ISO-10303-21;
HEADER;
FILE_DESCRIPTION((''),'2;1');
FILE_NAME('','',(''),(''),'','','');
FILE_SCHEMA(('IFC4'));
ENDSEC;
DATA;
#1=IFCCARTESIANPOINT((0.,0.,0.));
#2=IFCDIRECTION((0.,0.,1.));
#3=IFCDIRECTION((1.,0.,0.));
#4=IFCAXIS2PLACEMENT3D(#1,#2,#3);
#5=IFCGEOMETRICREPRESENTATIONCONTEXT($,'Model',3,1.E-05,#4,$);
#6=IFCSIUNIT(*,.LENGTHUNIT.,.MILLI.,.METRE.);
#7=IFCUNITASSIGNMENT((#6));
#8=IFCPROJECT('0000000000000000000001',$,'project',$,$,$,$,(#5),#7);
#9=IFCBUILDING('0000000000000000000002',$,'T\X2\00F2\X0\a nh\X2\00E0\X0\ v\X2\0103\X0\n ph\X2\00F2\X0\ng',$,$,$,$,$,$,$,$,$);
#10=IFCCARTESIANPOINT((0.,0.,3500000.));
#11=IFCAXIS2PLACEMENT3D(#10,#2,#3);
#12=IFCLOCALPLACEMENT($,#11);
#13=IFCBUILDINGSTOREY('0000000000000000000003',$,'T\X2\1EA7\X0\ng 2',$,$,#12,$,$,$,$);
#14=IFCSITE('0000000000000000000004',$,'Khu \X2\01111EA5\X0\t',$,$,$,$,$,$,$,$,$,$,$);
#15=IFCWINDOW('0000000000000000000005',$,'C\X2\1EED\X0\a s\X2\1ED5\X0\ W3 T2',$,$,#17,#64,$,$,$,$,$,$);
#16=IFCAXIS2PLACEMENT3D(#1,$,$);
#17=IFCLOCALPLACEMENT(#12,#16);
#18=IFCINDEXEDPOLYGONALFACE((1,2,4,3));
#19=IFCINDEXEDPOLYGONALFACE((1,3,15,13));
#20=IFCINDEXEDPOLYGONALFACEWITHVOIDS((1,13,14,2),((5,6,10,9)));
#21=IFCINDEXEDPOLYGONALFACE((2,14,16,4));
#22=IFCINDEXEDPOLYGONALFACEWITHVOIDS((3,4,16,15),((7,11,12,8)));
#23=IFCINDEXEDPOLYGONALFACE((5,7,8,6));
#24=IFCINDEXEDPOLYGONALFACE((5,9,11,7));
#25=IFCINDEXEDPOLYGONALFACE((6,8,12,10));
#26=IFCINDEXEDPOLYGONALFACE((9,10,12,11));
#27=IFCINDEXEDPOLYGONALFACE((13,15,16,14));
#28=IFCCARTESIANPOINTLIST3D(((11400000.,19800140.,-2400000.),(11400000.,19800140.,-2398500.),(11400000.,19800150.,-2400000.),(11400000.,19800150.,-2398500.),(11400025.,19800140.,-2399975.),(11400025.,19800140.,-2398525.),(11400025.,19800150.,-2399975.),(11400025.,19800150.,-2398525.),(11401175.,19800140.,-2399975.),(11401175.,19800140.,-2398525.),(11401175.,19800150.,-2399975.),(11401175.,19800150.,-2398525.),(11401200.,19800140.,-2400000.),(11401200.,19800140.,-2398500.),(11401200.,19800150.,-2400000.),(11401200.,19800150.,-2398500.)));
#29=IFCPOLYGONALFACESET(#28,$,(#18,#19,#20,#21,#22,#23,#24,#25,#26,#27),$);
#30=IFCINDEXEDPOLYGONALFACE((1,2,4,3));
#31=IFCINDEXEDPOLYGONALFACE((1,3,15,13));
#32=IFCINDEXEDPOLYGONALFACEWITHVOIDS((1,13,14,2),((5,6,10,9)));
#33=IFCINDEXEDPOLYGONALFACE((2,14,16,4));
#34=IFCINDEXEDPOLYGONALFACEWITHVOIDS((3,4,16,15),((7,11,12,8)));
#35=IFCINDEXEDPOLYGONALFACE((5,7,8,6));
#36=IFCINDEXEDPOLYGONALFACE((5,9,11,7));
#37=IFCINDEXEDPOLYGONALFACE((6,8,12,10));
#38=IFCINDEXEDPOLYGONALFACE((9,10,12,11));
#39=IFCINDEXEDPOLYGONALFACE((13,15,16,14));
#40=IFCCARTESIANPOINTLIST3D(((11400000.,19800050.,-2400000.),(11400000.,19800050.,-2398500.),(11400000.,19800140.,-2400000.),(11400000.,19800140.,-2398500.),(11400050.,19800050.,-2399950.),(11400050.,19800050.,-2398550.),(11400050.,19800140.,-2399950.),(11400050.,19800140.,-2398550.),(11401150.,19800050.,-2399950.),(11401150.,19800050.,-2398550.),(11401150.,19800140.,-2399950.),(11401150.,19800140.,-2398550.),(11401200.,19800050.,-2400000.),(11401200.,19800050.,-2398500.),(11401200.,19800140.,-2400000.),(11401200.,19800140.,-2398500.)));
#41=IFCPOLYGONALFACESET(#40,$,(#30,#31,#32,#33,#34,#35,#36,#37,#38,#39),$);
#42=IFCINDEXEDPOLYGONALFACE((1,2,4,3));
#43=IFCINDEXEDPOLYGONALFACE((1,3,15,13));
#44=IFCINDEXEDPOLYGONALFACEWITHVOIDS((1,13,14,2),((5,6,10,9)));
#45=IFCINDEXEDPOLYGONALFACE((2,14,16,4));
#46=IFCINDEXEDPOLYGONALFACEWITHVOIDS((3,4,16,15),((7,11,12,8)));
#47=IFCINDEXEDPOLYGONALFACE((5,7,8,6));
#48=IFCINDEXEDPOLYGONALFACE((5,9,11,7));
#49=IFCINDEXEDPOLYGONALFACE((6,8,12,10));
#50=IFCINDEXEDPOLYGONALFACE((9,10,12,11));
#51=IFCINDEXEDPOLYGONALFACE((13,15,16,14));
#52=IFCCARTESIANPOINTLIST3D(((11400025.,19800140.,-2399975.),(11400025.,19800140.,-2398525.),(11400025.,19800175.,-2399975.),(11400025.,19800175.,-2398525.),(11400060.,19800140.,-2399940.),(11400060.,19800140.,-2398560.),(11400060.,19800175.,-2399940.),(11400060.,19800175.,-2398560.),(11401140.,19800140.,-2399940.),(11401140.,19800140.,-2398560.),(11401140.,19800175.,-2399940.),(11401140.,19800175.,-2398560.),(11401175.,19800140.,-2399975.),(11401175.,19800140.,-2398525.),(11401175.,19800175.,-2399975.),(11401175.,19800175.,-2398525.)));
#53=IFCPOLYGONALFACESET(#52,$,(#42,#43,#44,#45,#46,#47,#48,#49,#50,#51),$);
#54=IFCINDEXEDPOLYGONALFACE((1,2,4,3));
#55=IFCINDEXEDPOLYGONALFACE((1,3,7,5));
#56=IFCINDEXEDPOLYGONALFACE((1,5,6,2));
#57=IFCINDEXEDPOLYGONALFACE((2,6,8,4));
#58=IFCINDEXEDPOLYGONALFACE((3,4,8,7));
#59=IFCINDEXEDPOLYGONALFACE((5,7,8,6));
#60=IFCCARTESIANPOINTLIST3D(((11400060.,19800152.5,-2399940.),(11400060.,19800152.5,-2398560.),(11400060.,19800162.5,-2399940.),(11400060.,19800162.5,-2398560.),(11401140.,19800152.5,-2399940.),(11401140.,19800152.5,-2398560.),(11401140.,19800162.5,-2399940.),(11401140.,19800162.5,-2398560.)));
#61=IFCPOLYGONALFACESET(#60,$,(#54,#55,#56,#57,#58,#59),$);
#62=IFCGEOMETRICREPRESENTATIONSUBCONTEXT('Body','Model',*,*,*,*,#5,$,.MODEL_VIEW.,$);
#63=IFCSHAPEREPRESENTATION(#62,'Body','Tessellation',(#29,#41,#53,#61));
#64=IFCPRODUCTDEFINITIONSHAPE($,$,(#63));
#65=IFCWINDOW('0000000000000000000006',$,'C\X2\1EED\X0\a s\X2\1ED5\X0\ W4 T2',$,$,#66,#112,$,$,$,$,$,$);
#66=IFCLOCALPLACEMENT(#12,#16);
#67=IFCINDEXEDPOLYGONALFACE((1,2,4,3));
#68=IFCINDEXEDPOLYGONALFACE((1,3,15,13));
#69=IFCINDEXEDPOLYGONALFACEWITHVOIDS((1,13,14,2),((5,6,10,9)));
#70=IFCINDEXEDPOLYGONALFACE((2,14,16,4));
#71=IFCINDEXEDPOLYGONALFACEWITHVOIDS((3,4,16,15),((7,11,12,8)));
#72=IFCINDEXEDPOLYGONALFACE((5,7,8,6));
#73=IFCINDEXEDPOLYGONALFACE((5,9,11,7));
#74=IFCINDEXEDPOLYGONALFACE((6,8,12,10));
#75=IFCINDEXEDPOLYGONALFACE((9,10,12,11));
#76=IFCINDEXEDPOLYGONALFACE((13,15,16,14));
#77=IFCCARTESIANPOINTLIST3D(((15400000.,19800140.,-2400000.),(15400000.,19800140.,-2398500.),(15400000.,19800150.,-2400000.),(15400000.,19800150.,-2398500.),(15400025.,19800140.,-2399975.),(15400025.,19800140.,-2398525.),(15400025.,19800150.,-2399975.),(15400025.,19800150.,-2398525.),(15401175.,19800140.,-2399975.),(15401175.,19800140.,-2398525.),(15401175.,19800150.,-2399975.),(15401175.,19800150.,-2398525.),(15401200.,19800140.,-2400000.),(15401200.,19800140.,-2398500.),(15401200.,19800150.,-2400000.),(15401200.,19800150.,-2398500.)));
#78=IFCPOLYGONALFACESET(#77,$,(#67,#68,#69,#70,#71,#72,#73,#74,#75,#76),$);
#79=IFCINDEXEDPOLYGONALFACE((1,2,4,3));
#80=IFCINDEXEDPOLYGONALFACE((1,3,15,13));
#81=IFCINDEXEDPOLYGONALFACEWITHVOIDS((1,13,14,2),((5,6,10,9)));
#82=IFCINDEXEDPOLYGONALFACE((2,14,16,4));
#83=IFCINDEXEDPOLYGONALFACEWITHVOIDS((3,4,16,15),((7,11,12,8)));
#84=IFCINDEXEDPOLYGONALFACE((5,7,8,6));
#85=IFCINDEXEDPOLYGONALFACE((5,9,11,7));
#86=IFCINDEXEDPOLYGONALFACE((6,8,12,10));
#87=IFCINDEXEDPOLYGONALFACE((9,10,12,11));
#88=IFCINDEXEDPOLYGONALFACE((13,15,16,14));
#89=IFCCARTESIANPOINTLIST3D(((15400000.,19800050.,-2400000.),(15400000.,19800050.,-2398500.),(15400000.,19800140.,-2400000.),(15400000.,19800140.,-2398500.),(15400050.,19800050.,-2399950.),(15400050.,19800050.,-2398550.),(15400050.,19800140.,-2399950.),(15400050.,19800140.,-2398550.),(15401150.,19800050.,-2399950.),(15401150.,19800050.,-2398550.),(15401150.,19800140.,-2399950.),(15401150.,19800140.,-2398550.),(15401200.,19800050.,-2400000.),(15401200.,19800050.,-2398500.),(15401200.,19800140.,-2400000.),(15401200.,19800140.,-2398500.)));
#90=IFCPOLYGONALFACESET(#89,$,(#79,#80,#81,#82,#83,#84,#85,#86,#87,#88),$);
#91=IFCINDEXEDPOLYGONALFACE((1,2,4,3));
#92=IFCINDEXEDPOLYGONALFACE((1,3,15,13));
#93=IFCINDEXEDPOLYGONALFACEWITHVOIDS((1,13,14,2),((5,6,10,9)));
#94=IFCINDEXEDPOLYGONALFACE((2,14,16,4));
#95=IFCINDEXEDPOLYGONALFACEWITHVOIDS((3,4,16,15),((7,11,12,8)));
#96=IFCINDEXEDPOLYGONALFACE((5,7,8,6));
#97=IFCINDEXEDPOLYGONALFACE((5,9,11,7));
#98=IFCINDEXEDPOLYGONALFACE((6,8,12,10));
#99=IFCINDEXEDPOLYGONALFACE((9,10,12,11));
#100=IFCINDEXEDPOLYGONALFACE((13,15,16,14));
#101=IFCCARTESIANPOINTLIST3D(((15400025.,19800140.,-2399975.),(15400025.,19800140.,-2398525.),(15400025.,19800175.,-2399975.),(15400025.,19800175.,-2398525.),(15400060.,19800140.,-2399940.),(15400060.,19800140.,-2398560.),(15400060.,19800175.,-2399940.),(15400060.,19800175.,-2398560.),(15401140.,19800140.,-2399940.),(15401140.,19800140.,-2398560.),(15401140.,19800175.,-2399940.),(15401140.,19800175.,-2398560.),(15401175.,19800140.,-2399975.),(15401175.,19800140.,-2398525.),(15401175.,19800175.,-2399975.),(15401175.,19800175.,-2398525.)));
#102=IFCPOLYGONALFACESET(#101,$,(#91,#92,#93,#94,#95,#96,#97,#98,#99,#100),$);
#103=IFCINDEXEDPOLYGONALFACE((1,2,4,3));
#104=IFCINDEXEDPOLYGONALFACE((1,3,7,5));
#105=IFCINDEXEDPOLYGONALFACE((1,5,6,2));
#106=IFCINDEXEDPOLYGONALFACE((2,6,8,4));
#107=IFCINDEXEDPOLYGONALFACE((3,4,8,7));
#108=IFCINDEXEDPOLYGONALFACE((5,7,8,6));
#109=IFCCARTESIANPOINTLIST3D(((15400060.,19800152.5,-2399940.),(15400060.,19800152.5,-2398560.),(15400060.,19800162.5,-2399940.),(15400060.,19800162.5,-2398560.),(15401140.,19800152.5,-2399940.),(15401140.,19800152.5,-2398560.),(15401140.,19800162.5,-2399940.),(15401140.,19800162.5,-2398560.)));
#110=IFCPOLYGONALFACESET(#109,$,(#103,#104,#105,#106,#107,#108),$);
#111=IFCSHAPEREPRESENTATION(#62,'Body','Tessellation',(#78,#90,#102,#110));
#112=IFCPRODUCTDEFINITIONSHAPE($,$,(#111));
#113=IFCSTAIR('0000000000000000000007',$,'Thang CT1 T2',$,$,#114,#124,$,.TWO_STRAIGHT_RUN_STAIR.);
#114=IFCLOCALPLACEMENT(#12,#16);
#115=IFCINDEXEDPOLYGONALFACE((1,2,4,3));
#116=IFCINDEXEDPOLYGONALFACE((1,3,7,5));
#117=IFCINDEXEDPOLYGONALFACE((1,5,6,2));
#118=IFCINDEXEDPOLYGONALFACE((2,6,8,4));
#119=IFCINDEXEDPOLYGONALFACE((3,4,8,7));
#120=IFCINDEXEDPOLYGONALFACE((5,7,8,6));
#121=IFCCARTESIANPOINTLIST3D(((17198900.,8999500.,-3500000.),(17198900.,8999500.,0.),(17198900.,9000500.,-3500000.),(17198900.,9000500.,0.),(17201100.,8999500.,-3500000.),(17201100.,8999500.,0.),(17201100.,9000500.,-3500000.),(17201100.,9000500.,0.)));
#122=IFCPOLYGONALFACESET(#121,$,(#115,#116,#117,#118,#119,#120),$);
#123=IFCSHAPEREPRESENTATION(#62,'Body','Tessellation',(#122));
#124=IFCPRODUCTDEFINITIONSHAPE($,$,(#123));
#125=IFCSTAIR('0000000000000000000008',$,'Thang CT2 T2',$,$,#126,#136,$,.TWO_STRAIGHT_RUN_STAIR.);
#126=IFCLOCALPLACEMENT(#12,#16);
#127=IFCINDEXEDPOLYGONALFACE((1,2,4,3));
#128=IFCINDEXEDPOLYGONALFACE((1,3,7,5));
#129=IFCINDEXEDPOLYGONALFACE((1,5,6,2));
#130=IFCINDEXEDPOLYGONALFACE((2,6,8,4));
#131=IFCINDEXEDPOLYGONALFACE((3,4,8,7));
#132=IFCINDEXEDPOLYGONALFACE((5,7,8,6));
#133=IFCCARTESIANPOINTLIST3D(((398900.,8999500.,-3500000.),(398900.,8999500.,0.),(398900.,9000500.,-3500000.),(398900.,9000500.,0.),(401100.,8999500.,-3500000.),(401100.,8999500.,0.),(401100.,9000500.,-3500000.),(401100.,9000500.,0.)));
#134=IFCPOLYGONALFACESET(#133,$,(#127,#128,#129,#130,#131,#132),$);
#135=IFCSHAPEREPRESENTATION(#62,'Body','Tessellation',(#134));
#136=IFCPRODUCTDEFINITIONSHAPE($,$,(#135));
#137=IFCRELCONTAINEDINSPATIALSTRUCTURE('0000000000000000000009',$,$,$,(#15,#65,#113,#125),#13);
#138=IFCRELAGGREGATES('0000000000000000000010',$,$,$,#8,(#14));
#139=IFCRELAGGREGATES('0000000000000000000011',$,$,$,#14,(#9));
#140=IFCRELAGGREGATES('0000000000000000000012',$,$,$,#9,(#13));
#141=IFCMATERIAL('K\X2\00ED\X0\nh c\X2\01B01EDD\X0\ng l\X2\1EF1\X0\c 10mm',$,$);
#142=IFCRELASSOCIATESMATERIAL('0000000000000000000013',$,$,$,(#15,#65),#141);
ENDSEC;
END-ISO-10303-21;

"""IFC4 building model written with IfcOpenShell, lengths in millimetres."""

from ifc_helpers import new_model, entity, si_unit, frame, origin_with_axes, place, context, subcontext, project, spatial, line, indexed_curve, outline, extrude, material, element, save


model = new_model("IFC4")

# Units and contexts
model_context = context("Model", 3, precision=1e-05, world=origin_with_axes())
body_context = subcontext(model_context, "Body", "Model", "MODEL_VIEW")
ifc_project = project(units=[si_unit("LENGTHUNIT", "METRE", prefix="MILLI")], contexts=[model_context])

# Site, building, storey
site = spatial("IfcSite", under=ifc_project, Name="Khu đất")
building = spatial("IfcBuilding", under=site, Name="Tòa nhà văn phòng")
storey_placement = place(None, frame((0.0, 0.0, 3500000.0), z_axis=(0.0, 0.0, 1.0), x_axis=(1.0, 0.0, 0.0)))
storey = spatial("IfcBuildingStorey", under=building, at=storey_placement, Name="Tầng 2")

# Windows
ifc_material_1 = material(Name="Kính cường lực 10mm")
for number, where, z_axis, x_axis, name in (
    (1, (11400000.0, 19800000.0, -2400000.0), (0.0, 0.0, 1.0), (1.0, 0.0, 0.0), "Cửa sổ W3 T2"),
    (2, (15400000.0, 19800000.0, -2400000.0), (0.0, 0.0, 1.0), (1.0, 0.0, 0.0), "Cửa sổ W4 T2"),
):
    element("IfcWindow", number, at=place(storey_placement, frame(where, z_axis=z_axis, x_axis=x_axis)), inside=storey, material=ifc_material_1, Name=name, context=body_context, shape_type="SolidModel", body=[
        extrude(outline(indexed_curve([(0.0, 0.0), (1200.0, 0.0), (1200.0, 1500.0), (0.0, 1500.0)], segments=[line(1, 2, 3, 4, 1)]), holes=[indexed_curve([(25.0, 25.0), (1175.0, 25.0), (1175.0, 1475.0), (25.0, 1475.0)], segments=[line(1, 2, 3, 4, 1)])]), frame((0.0, 140.0, 0.0), z_axis=(0.0, -1.0, 0.0), x_axis=(1.0, 0.0, 0.0)), (0.0, 0.0, -1.0), 10.0),
        extrude(outline(indexed_curve([(0.0, 0.0), (1200.0, 0.0), (1200.0, 1500.0), (0.0, 1500.0)], segments=[line(1, 2, 3, 4, 1)]), holes=[indexed_curve([(50.0, 50.0), (1150.0, 50.0), (1150.0, 1450.0), (50.0, 1450.0)], segments=[line(1, 2, 3, 4, 1)])]), frame((0.0, 50.0, 0.0), z_axis=(0.0, -1.0, 0.0), x_axis=(1.0, 0.0, 0.0)), (0.0, 0.0, -1.0), 90.0),
        extrude(outline(indexed_curve([(0.0, 0.0), (1150.0, 0.0), (1150.0, 1450.0), (0.0, 1450.0)], segments=[line(1, 2, 3, 4, 1)]), holes=[indexed_curve([(35.0, 35.0), (1115.0, 35.0), (1115.0, 1415.0), (35.0, 1415.0)], segments=[line(1, 2, 3, 4, 1)])]), frame((25.0, 140.0, 25.0), z_axis=(0.0, -1.0, 0.0), x_axis=(1.0, 0.0, 0.0)), (0.0, 0.0, -1.0), 35.0),
        extrude(outline(indexed_curve([(35.0, 35.0), (1115.0, 35.0), (1115.0, 1415.0), (35.0, 1415.0)], segments=[line(1, 2, 3, 4, 1)])), frame((25.0, 152.5, 25.0), z_axis=(0.0, -1.0, 0.0), x_axis=(1.0, 0.0, 0.0)), (0.0, 0.0, -1.0), 10.0),
    ])

# Stairs
for number, where, z_axis, x_axis, name in (
    (3, (17200000.0, 9000000.0, -3500000.0), (0.0, 0.0, 1.0), (1.0, 0.0, 0.0), "Thang CT1 T2"),
    (4, (400000.0, 9000000.0, -3500000.0), (0.0, 0.0, 1.0), (1.0, 0.0, 0.0), "Thang CT2 T2"),
):
    element("IfcStair", number, at=place(storey_placement, frame(where, z_axis=z_axis, x_axis=x_axis)), inside=storey, Name=name, PredefinedType="TWO_STRAIGHT_RUN_STAIR", context=body_context, shape_type="SweptSolid", body=[
        extrude(entity("IfcRectangleProfileDef", None, None, None, 2200.0, 1000.0), origin_with_axes(), (0.0, 0.0, 1.0), 3500000.0),
    ])

save(model, "model.ifc")
